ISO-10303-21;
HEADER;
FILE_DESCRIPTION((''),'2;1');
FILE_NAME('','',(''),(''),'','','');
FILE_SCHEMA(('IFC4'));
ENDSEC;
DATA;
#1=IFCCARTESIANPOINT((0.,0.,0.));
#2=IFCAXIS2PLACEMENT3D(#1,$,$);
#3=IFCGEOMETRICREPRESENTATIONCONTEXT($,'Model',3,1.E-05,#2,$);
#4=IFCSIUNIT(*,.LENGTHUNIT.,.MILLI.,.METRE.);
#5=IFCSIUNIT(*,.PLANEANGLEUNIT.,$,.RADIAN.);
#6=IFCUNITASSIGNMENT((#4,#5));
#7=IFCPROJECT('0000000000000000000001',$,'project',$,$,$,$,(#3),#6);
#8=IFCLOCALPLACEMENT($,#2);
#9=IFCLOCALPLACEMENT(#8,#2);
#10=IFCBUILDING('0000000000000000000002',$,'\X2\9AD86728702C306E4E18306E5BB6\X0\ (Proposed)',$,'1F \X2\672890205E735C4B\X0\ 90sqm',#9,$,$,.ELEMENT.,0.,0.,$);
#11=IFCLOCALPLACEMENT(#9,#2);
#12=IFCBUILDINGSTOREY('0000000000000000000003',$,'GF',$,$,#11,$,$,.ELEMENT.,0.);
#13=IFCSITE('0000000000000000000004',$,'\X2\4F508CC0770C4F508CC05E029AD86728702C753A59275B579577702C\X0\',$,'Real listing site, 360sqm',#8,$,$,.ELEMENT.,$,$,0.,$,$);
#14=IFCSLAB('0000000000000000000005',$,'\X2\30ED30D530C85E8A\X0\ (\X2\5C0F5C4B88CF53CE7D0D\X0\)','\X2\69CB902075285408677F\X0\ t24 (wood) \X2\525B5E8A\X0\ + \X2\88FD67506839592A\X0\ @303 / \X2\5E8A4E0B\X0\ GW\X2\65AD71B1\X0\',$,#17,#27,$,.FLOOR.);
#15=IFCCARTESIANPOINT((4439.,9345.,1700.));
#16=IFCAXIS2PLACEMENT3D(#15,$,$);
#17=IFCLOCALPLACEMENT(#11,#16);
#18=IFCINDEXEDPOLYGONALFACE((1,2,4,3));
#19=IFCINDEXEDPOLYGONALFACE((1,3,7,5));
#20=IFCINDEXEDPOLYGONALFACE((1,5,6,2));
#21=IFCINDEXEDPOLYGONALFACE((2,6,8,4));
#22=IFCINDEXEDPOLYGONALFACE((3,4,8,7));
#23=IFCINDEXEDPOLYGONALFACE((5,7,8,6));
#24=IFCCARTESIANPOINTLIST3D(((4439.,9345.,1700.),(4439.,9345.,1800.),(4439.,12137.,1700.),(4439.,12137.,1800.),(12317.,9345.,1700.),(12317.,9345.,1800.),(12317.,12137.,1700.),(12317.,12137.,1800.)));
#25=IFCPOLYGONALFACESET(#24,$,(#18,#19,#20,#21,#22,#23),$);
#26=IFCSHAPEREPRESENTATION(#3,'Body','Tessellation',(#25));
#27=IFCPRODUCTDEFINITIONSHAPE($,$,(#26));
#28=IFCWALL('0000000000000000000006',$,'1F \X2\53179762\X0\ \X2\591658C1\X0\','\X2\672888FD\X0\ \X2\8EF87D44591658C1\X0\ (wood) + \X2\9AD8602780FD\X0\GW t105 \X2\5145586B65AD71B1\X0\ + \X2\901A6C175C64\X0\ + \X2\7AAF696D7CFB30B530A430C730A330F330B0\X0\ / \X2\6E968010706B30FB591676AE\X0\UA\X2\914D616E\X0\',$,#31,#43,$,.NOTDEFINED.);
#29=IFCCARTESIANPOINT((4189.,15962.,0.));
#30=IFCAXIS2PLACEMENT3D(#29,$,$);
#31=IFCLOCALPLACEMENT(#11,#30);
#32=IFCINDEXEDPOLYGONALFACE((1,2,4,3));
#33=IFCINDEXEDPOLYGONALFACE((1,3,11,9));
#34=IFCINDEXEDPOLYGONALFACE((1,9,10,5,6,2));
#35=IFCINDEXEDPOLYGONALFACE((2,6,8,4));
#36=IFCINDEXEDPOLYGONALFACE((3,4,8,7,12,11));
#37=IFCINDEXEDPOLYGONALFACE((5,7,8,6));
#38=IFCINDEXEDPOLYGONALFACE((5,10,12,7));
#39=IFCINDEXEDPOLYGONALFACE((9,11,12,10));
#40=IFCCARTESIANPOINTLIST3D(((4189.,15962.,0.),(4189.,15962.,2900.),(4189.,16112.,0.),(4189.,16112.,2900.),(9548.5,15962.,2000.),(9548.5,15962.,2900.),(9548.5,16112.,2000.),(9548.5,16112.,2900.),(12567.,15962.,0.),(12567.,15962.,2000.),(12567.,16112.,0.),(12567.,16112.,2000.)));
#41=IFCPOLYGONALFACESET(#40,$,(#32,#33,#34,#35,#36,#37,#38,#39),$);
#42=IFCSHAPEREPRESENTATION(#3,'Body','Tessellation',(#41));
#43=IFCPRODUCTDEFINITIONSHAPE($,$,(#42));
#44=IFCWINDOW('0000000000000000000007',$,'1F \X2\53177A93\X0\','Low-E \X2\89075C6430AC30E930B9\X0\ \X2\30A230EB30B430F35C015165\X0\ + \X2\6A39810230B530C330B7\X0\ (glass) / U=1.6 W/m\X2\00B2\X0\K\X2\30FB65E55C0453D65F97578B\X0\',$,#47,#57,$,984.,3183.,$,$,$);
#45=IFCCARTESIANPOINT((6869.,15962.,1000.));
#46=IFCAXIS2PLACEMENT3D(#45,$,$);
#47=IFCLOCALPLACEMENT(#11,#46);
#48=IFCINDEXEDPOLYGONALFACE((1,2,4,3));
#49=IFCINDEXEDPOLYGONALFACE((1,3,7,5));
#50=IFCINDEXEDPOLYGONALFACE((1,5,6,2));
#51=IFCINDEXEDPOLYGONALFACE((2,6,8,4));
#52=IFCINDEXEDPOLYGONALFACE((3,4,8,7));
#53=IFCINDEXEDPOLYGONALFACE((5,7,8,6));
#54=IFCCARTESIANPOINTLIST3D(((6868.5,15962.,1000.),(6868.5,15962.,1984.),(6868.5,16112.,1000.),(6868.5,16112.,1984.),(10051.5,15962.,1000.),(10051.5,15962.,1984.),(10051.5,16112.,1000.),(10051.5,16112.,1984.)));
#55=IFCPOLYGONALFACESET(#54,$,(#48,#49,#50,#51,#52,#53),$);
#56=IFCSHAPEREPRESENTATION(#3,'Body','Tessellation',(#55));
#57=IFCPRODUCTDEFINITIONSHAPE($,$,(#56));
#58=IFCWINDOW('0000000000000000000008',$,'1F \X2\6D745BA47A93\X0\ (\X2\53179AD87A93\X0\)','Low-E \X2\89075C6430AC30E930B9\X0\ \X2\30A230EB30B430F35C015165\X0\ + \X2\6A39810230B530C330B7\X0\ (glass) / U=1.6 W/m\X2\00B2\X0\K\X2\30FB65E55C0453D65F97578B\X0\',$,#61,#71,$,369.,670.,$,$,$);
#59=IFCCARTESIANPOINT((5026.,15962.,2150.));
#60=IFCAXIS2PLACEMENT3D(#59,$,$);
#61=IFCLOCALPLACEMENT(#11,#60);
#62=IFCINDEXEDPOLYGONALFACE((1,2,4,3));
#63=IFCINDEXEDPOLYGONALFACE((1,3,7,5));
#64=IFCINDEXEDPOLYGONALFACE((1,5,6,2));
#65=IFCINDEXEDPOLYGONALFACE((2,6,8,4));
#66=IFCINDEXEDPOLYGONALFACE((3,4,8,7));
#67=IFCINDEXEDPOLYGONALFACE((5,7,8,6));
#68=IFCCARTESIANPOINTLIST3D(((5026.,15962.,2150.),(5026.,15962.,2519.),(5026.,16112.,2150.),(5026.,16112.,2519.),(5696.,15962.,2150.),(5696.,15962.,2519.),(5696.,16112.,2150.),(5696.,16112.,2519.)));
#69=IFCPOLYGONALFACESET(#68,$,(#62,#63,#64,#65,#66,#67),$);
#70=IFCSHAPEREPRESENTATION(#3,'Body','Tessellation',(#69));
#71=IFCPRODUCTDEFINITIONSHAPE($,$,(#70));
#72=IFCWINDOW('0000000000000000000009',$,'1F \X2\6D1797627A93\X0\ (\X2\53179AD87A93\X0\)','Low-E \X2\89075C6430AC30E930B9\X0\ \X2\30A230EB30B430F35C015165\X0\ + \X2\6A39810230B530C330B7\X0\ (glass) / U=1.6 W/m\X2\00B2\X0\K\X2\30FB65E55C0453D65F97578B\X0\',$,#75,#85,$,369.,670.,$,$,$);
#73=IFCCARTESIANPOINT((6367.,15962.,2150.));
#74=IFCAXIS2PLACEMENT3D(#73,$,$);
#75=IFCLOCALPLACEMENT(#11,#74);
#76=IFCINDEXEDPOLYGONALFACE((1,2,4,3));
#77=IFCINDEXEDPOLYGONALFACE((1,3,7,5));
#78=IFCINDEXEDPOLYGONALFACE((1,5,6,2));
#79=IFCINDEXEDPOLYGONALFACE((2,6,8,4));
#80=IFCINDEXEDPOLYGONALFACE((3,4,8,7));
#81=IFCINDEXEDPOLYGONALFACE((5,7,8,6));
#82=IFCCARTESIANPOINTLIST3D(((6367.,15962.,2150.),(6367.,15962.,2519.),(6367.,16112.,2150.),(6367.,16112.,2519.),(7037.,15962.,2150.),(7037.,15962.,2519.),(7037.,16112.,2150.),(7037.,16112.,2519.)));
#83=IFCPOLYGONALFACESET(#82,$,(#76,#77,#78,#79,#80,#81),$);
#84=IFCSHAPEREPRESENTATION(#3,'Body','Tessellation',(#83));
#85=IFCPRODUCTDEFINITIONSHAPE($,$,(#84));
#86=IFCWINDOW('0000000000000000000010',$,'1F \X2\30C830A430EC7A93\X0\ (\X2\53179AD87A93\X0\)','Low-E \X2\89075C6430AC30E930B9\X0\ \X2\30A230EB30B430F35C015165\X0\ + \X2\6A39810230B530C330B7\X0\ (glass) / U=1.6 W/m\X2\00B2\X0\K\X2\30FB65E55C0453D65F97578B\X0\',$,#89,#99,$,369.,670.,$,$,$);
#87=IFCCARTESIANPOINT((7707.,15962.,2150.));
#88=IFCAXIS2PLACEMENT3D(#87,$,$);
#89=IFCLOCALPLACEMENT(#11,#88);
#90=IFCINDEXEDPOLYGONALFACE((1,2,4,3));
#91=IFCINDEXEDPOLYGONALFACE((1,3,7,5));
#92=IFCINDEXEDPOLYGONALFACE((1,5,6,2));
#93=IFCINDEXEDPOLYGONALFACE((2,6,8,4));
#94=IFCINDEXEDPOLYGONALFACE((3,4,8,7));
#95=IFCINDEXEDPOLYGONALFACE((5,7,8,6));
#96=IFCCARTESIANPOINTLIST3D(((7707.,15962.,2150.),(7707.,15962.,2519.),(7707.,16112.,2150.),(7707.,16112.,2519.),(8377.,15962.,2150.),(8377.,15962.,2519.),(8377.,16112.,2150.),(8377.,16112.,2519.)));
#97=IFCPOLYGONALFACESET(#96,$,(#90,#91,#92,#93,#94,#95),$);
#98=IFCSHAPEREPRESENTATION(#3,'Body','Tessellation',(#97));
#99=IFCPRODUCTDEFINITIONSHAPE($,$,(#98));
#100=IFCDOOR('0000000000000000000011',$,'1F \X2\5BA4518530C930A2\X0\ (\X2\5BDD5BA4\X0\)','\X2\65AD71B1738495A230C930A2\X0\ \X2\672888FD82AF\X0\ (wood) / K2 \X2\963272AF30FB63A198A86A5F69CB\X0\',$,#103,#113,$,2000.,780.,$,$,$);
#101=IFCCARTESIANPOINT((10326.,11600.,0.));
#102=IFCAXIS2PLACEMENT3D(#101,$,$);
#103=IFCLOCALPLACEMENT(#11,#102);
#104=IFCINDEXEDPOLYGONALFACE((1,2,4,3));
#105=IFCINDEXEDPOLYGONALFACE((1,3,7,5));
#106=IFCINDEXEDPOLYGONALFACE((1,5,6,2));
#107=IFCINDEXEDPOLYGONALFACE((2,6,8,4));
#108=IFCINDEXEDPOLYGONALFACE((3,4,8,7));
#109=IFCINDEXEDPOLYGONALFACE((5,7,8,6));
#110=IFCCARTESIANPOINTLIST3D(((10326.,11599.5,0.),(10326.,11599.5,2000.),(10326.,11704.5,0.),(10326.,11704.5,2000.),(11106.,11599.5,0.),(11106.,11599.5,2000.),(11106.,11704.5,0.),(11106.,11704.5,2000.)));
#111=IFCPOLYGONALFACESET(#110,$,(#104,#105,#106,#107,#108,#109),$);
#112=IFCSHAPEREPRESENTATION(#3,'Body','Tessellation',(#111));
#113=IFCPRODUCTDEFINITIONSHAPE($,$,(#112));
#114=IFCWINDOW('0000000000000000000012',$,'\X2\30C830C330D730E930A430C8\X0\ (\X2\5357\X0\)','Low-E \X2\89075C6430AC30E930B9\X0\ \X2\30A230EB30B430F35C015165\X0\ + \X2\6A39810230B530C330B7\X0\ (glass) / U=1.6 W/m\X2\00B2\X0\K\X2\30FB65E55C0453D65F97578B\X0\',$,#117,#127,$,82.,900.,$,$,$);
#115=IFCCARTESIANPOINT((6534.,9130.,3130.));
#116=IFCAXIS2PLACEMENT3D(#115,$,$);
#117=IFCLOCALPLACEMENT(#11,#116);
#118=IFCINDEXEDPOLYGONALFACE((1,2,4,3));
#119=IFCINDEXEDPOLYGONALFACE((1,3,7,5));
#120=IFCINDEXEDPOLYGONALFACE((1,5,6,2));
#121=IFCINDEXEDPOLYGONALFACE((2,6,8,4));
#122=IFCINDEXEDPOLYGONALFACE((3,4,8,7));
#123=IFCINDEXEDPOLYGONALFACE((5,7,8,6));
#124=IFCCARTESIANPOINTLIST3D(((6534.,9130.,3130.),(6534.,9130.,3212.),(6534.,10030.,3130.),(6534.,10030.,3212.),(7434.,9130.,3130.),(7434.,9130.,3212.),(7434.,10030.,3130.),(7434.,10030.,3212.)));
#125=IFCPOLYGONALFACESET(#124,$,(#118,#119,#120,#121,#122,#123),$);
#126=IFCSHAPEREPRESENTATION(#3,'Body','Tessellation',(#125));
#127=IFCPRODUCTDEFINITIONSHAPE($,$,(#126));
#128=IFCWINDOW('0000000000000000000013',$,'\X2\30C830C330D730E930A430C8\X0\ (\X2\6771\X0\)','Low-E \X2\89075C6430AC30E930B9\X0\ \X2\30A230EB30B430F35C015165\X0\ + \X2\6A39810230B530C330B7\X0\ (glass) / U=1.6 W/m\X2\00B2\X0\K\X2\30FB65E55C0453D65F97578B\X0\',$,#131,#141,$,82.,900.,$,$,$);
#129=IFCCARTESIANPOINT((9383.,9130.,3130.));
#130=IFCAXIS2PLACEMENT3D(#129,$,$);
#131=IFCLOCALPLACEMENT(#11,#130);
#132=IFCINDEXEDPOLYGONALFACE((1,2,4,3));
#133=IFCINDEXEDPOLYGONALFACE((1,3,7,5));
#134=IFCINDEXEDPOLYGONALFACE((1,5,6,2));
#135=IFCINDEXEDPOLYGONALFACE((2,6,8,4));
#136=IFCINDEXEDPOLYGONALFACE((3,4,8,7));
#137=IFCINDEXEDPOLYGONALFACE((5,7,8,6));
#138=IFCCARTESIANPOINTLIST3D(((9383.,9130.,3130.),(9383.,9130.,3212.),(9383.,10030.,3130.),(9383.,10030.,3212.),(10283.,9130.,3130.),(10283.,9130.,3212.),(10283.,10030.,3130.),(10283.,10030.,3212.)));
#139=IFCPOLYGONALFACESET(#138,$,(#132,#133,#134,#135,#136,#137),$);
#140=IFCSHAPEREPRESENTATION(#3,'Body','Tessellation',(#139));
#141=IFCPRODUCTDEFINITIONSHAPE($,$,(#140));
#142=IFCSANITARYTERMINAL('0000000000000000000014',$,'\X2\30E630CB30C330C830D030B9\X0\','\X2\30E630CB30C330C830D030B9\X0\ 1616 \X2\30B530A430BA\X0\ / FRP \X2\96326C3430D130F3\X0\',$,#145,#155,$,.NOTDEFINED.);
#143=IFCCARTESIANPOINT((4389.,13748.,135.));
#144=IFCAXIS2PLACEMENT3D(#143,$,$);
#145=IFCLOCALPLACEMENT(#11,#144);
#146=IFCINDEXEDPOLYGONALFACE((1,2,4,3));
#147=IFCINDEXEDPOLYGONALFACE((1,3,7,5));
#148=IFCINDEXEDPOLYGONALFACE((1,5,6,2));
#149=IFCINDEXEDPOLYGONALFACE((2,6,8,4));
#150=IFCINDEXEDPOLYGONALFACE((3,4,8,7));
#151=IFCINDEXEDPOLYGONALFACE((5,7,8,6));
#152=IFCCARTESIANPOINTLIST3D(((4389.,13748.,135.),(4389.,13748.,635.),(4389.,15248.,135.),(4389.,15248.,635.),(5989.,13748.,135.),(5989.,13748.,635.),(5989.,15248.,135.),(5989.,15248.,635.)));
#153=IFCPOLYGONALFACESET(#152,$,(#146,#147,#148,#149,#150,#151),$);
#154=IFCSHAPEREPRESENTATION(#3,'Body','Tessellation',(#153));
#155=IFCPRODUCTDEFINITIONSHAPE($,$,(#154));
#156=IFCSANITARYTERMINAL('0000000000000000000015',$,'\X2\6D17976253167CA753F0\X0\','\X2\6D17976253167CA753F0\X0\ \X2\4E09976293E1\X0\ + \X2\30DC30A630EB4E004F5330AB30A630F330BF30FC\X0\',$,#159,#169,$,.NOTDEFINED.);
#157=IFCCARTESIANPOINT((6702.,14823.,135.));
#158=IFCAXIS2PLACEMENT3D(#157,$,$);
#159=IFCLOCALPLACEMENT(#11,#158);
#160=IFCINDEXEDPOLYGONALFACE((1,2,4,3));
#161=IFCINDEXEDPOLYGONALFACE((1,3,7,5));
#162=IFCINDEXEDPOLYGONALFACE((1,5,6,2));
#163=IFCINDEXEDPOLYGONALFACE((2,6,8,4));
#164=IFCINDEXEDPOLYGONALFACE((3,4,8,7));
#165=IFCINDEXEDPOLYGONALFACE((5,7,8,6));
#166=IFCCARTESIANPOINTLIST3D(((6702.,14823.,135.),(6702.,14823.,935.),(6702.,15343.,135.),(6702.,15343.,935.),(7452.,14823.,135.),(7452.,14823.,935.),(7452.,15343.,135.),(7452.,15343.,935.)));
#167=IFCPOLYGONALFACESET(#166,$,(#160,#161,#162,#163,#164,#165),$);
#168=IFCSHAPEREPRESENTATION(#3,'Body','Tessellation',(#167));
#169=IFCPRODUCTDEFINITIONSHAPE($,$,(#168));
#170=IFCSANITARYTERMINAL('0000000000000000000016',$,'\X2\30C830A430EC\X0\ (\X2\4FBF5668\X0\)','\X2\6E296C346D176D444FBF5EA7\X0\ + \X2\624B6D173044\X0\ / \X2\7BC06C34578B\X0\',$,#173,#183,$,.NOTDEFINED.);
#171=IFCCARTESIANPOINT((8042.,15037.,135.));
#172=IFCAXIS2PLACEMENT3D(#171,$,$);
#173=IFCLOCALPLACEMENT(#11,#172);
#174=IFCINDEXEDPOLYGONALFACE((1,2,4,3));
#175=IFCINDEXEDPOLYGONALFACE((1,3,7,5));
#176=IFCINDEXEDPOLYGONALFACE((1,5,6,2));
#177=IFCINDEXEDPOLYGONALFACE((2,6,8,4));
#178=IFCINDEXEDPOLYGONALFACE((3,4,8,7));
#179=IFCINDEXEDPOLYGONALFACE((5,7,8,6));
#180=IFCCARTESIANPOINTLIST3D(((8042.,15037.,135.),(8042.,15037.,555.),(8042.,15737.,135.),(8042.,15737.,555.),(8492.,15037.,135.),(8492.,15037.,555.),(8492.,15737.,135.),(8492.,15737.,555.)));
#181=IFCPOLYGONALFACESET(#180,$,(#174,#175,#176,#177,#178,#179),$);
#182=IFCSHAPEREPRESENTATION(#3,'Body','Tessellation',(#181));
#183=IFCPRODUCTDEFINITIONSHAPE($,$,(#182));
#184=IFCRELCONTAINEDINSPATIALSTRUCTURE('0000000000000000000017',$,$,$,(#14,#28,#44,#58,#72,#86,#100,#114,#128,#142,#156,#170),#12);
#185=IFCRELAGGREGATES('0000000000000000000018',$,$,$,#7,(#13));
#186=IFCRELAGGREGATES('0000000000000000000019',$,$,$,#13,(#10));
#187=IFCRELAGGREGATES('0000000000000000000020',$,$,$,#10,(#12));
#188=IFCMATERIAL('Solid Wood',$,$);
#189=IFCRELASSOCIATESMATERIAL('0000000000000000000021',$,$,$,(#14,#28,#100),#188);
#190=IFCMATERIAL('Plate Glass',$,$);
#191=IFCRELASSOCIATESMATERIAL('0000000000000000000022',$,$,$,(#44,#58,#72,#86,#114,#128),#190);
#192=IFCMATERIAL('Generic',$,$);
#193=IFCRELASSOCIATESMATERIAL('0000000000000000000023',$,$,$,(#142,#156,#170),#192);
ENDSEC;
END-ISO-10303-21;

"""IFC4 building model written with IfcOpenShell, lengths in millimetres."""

from ifc_helpers import new_model, si_unit, frame, frame_2d, origin, place, context, project, spatial, rectangle, extrude, material, element, fill, save


model = new_model("IFC4")

# Units and contexts
model_context = context("Model", 3, precision=1e-05, world=origin())
ifc_project = project(units=[si_unit("LENGTHUNIT", "METRE", prefix="MILLI"), si_unit("PLANEANGLEUNIT", "RADIAN")], contexts=[model_context])

# Site, building, storey
site_placement = place(None, origin())
site = spatial("IfcSite", under=ifc_project, at=site_placement, Name="佐賀県佐賀市高木瀬町大字長瀬", ObjectType="Real listing site, 360sqm", CompositionType="ELEMENT", RefElevation=0.0)
building_placement = place(site_placement, origin())
building = spatial("IfcBuilding", under=site, at=building_placement, Name="高木瀬の丘の家 (Proposed)", ObjectType="1F 木造平屋 90sqm", CompositionType="ELEMENT", ElevationOfRefHeight=0.0, ElevationOfTerrain=0.0)
storey_placement = place(building_placement, origin())
storey = spatial("IfcBuildingStorey", under=building, at=storey_placement, Name="GF", CompositionType="ELEMENT", Elevation=0.0)

# Slab
ifc_material_1 = material(Name="Solid Wood")
slab_placement = place(storey_placement, frame((4439.0, 9345.0, 1700.0)))
element("IfcSlab", 1, at=slab_placement, inside=storey, material=ifc_material_1, Name="ロフト床 (小屋裏収納)", Description="構造用合板 t24 (wood) 剛床 + 製材根太 @303 / 床下 GW断熱", PredefinedType="FLOOR", context=model_context, shape_type="SweptSolid", body=[
    extrude(rectangle(XDim=7878.0, YDim=2792.0, at=frame_2d((3939.0, 1396.0))), frame((4439.0, 9345.0, 1700.0)), (0.0, 0.0, 1.0), 100.0),
])

# Wall, openings, windows
wall_1_placement = place(storey_placement, frame((4189.0, 15962.0, 0.0)))
wall_1 = element("IfcWall", 2, at=wall_1_placement, inside=storey, material=ifc_material_1, Name="1F 北面 外壁", Description="木製 軸組外壁 (wood) + 高性能GW t105 充填断熱 + 通気層 + 窯業系サイディング / 準耐火・外皮UA配慮", PredefinedType="NOTDEFINED", context=model_context, shape_type="SweptSolid", body=[
    extrude(rectangle(XDim=8378.0, YDim=150.0, at=frame_2d((4189.0, 75.0))), frame((4189.0, 15962.0, 0.0)), (0.0, 0.0, 1.0), 2900.0),
])
opening_1_placement = place(storey_placement, frame((6869.0, 15962.0, 1000.0)))
opening_1 = element("IfcOpeningElement", 3, at=opening_1_placement, cuts=wall_1, PredefinedType="NOTDEFINED", context=model_context, shape_type="SweptSolid", body=[
    extrude(rectangle(XDim=3183.0, YDim=150.0, at=frame_2d((1591.0, 75.0))), frame((6869.0, 15962.0, 1000.0)), (0.0, 0.0, 1.0), 984.0),
])
opening_2_placement = place(storey_placement, frame((5026.0, 15962.0, 2150.0)))
opening_2 = element("IfcOpeningElement", 4, at=opening_2_placement, cuts=wall_1, PredefinedType="NOTDEFINED", context=model_context, shape_type="SweptSolid", body=[
    extrude(rectangle(XDim=670.0, YDim=150.0, at=frame_2d((335.0, 75.0))), frame((5026.0, 15962.0, 2150.0)), (0.0, 0.0, 1.0), 369.0),
])
opening_3_placement = place(storey_placement, frame((6367.0, 15962.0, 2150.0)))
opening_3 = element("IfcOpeningElement", 5, at=opening_3_placement, cuts=wall_1, PredefinedType="NOTDEFINED", context=model_context, shape_type="SweptSolid", body=[
    extrude(rectangle(XDim=670.0, YDim=150.0, at=frame_2d((335.0, 75.0))), frame((6367.0, 15962.0, 2150.0)), (0.0, 0.0, 1.0), 369.0),
])
opening_4_placement = place(storey_placement, frame((7707.0, 15962.0, 2150.0)))
opening_4 = element("IfcOpeningElement", 6, at=opening_4_placement, cuts=wall_1, PredefinedType="NOTDEFINED", context=model_context, shape_type="SweptSolid", body=[
    extrude(rectangle(XDim=670.0, YDim=150.0, at=frame_2d((335.0, 75.0))), frame((7707.0, 15962.0, 2150.0)), (0.0, 0.0, 1.0), 369.0),
])
ifc_material_2 = material(Name="Plate Glass")
window_1_placement = place(storey_placement, frame((6869.0, 15962.0, 1000.0)))
window_1 = element("IfcWindow", 7, at=window_1_placement, inside=storey, material=ifc_material_2, Name="1F 北窓", Description="Low-E 複層ガラス アルゴン封入 + 樹脂サッシ (glass) / U=1.6 W/m²K・日射取得型", OverallHeight=984.0, OverallWidth=3183.0, context=model_context, shape_type="SweptSolid", body=[
    extrude(rectangle(XDim=3183.0, YDim=150.0, at=frame_2d((1591.0, 75.0))), frame((6869.0, 15962.0, 1000.0)), (0.0, 0.0, 1.0), 984.0),
])
fill(opening_1, window_1)
window_2_placement = place(storey_placement, frame((5026.0, 15962.0, 2150.0)))
window_2 = element("IfcWindow", 8, at=window_2_placement, inside=storey, material=ifc_material_2, Name="1F 浴室窓 (北高窓)", Description="Low-E 複層ガラス アルゴン封入 + 樹脂サッシ (glass) / U=1.6 W/m²K・日射取得型", OverallHeight=369.0, OverallWidth=670.0, context=model_context, shape_type="SweptSolid", body=[
    extrude(rectangle(XDim=670.0, YDim=150.0, at=frame_2d((335.0, 75.0))), frame((5026.0, 15962.0, 2150.0)), (0.0, 0.0, 1.0), 369.0),
])
fill(opening_2, window_2)
window_3_placement = place(storey_placement, frame((6367.0, 15962.0, 2150.0)))
window_3 = element("IfcWindow", 9, at=window_3_placement, inside=storey, material=ifc_material_2, Name="1F 洗面窓 (北高窓)", Description="Low-E 複層ガラス アルゴン封入 + 樹脂サッシ (glass) / U=1.6 W/m²K・日射取得型", OverallHeight=369.0, OverallWidth=670.0, context=model_context, shape_type="SweptSolid", body=[
    extrude(rectangle(XDim=670.0, YDim=150.0, at=frame_2d((335.0, 75.0))), frame((6367.0, 15962.0, 2150.0)), (0.0, 0.0, 1.0), 369.0),
])
fill(opening_3, window_3)
window_4_placement = place(storey_placement, frame((7707.0, 15962.0, 2150.0)))
window_4 = element("IfcWindow", 10, at=window_4_placement, inside=storey, material=ifc_material_2, Name="1F トイレ窓 (北高窓)", Description="Low-E 複層ガラス アルゴン封入 + 樹脂サッシ (glass) / U=1.6 W/m²K・日射取得型", OverallHeight=369.0, OverallWidth=670.0, context=model_context, shape_type="SweptSolid", body=[
    extrude(rectangle(XDim=670.0, YDim=150.0, at=frame_2d((335.0, 75.0))), frame((7707.0, 15962.0, 2150.0)), (0.0, 0.0, 1.0), 369.0),
])
fill(opening_4, window_4)

# Door
door_1_placement = place(storey_placement, frame((10326.0, 11600.0, 0.0)))
element("IfcDoor", 11, at=door_1_placement, inside=storey, material=ifc_material_1, Name="1F 室内ドア (寝室)", Description="断熱玄関ドア 木製芯 (wood) / K2 防犯・採風機構", OverallHeight=2000.0, OverallWidth=780.0, context=model_context, shape_type="SweptSolid", body=[
    extrude(rectangle(XDim=780.0, YDim=105.0, at=frame_2d((390.0, 52.0))), frame((10326.0, 11600.0, 0.0)), (0.0, 0.0, 1.0), 2000.0),
])

# Windows
window_5_placement = place(storey_placement, frame((6534.0, 9130.0, 3130.0)))
element("IfcWindow", 12, at=window_5_placement, inside=storey, material=ifc_material_2, Name="トップライト (南)", Description="Low-E 複層ガラス アルゴン封入 + 樹脂サッシ (glass) / U=1.6 W/m²K・日射取得型", OverallHeight=82.0, OverallWidth=900.0, context=model_context, shape_type="SweptSolid", body=[
    extrude(rectangle(XDim=900.0, YDim=900.0, at=frame_2d((450.0, 450.0))), frame((6534.0, 9130.0, 3130.0)), (0.0, 0.0, 1.0), 82.0),
])
window_6_placement = place(storey_placement, frame((9383.0, 9130.0, 3130.0)))
element("IfcWindow", 13, at=window_6_placement, inside=storey, material=ifc_material_2, Name="トップライト (東)", Description="Low-E 複層ガラス アルゴン封入 + 樹脂サッシ (glass) / U=1.6 W/m²K・日射取得型", OverallHeight=82.0, OverallWidth=900.0, context=model_context, shape_type="SweptSolid", body=[
    extrude(rectangle(XDim=900.0, YDim=900.0, at=frame_2d((450.0, 450.0))), frame((9383.0, 9130.0, 3130.0)), (0.0, 0.0, 1.0), 82.0),
])

# Sanitary terminals
ifc_material_3 = material(Name="Generic")
sanitary_terminal_1_placement = place(storey_placement, frame((4389.0, 13748.0, 135.0)))
element("IfcSanitaryTerminal", 14, at=sanitary_terminal_1_placement, inside=storey, material=ifc_material_3, Name="ユニットバス", Description="ユニットバス 1616 サイズ / FRP 防水パン", PredefinedType="NOTDEFINED", context=model_context, shape_type="SweptSolid", body=[
    extrude(rectangle(XDim=1600.0, YDim=1500.0, at=frame_2d((800.0, 750.0))), frame((4389.0, 13748.0, 135.0)), (0.0, 0.0, 1.0), 500.0),
])
sanitary_terminal_2_placement = place(storey_placement, frame((6702.0, 14823.0, 135.0)))
element("IfcSanitaryTerminal", 15, at=sanitary_terminal_2_placement, inside=storey, material=ifc_material_3, Name="洗面化粧台", Description="洗面化粧台 三面鏡 + ボウル一体カウンター", PredefinedType="NOTDEFINED", context=model_context, shape_type="SweptSolid", body=[
    extrude(rectangle(XDim=750.0, YDim=520.0, at=frame_2d((375.0, 260.0))), frame((6702.0, 14823.0, 135.0)), (0.0, 0.0, 1.0), 800.0),
])
sanitary_terminal_3_placement = place(storey_placement, frame((8042.0, 15037.0, 135.0)))
element("IfcSanitaryTerminal", 16, at=sanitary_terminal_3_placement, inside=storey, material=ifc_material_3, Name="トイレ (便器)", Description="温水洗浄便座 + 手洗い / 節水型", PredefinedType="NOTDEFINED", context=model_context, shape_type="SweptSolid", body=[
    extrude(rectangle(XDim=450.0, YDim=700.0, at=frame_2d((225.0, 350.0))), frame((8042.0, 15037.0, 135.0)), (0.0, 0.0, 1.0), 420.0),
])

save(model, "model.ifc")
